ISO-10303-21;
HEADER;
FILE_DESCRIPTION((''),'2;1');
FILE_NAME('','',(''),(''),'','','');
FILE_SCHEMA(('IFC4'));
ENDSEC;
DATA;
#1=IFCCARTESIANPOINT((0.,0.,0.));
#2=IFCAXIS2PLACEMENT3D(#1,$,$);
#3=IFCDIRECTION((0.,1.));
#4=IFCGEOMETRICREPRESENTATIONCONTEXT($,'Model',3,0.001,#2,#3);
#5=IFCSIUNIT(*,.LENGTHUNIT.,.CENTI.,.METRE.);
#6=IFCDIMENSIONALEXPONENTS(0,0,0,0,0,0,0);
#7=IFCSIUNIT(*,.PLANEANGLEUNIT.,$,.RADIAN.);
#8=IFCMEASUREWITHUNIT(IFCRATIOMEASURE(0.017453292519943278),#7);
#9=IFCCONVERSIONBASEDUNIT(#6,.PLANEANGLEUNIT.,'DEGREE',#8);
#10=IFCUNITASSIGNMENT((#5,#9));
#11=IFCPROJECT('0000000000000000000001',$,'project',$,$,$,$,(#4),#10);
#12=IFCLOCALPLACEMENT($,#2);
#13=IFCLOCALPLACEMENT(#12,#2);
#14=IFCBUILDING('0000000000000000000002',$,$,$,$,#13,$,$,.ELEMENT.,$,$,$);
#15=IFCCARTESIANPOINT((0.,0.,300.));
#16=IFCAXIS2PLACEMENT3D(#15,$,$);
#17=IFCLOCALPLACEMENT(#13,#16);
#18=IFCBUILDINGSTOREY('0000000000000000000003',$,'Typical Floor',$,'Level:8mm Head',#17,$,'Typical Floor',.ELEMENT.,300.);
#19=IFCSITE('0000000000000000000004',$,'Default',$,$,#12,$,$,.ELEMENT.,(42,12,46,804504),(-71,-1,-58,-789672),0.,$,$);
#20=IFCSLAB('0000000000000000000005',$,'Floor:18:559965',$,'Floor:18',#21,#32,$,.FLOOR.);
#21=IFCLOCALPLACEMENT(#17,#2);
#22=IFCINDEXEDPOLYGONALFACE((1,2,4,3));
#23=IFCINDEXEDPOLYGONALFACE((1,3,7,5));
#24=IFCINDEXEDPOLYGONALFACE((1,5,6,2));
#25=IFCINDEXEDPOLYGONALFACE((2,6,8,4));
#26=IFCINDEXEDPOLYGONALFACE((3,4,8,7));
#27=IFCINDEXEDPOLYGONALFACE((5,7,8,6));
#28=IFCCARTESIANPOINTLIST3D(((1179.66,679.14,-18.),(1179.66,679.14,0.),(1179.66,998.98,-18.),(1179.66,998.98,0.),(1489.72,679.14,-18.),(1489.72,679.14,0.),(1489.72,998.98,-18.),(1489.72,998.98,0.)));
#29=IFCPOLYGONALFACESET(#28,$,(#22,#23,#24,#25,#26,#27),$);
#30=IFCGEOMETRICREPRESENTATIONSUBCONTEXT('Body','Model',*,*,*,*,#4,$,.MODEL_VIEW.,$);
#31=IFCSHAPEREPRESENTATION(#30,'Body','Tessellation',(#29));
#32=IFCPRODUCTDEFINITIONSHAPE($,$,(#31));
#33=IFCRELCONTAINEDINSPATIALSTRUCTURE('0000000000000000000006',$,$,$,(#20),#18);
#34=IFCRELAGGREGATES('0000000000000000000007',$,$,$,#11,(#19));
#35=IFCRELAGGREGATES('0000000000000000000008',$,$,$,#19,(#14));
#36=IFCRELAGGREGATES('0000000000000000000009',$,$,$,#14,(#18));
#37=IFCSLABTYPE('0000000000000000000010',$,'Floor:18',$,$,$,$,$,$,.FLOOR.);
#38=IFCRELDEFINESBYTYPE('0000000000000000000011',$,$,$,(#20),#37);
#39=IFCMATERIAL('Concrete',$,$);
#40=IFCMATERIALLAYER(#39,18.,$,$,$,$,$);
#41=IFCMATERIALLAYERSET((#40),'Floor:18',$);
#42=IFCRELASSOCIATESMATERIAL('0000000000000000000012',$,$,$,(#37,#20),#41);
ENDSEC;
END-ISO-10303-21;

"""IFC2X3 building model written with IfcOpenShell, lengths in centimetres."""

from ifc_helpers import new_model, entity, si_unit, converted_unit, direction, frame, frame_2d, origin, place, context, subcontext, project, spatial, rectangle, extrude, material, layer, layer_set, layer_usage, type_object, element, save


model = new_model("IFC2X3")

# Units and contexts
model_context = context("Model", 3, precision=0.001, world=origin(), true_north=direction((0.0, 1.0)))
body_context = subcontext(model_context, "Body", "Model", "MODEL_VIEW")
ifc_project = project(units=[si_unit("LENGTHUNIT", "METRE", prefix="CENTI"), converted_unit("PLANEANGLEUNIT", "DEGREE", entity("IfcRatioMeasure", 0.017453292519943278), si_unit("PLANEANGLEUNIT", "RADIAN"), dimensions=[0, 0, 0, 0, 0, 0, 0])], contexts=[model_context])

# Site, building, storey
site_placement = place(None, origin())
site = spatial("IfcSite", under=ifc_project, at=site_placement, Name="Default", CompositionType="ELEMENT", RefLatitude=(42, 12, 46, 804504), RefLongitude=(-71, -1, -58, -789672), RefElevation=0.0)
building_placement = place(site_placement, origin())
building = spatial("IfcBuilding", under=site, at=building_placement, CompositionType="ELEMENT")
storey_placement = place(building_placement, frame((0.0, 0.0, 300.0)))
storey = spatial("IfcBuildingStorey", under=building, at=storey_placement, Name="Typical Floor", ObjectType="Level:8mm Head", LongName="Typical Floor", CompositionType="ELEMENT", Elevation=300.0)

# Shared definitions
ifc_material = material(Name="Concrete")

# Slab
ifc_layer = layer(ifc_material, 18.0)
ifc_layer_set = layer_set([ifc_layer], Name="Floor:18")
ifc_layer_usage_1 = layer_usage(ifc_layer_set, "AXIS3", "POSITIVE", 0.0)
slab_type_1 = type_object("IfcSlabType", Name="Floor:18", PredefinedType="FLOOR", material=ifc_layer_set)
slab_1_placement = place(storey_placement, origin())
element("IfcSlab", 1, at=slab_1_placement, inside=storey, type_object=slab_type_1, material=ifc_layer_usage_1, Name="Floor:18:559965", ObjectType="Floor:18", PredefinedType="FLOOR", context=body_context, shape_type="SweptSolid", body=[
    extrude(rectangle(XDim=319.84, YDim=310.06, at=frame_2d((0.0, 0.0), x_axis=(1.0, 0.0))), frame((1334.69, 839.06, 0.0), z_axis=(0.0, 0.0, -1.0), x_axis=(0.0, 1.0, 0.0)), (0.0, 0.0, 1.0), 18.0),
])

save(model, "model.ifc")
